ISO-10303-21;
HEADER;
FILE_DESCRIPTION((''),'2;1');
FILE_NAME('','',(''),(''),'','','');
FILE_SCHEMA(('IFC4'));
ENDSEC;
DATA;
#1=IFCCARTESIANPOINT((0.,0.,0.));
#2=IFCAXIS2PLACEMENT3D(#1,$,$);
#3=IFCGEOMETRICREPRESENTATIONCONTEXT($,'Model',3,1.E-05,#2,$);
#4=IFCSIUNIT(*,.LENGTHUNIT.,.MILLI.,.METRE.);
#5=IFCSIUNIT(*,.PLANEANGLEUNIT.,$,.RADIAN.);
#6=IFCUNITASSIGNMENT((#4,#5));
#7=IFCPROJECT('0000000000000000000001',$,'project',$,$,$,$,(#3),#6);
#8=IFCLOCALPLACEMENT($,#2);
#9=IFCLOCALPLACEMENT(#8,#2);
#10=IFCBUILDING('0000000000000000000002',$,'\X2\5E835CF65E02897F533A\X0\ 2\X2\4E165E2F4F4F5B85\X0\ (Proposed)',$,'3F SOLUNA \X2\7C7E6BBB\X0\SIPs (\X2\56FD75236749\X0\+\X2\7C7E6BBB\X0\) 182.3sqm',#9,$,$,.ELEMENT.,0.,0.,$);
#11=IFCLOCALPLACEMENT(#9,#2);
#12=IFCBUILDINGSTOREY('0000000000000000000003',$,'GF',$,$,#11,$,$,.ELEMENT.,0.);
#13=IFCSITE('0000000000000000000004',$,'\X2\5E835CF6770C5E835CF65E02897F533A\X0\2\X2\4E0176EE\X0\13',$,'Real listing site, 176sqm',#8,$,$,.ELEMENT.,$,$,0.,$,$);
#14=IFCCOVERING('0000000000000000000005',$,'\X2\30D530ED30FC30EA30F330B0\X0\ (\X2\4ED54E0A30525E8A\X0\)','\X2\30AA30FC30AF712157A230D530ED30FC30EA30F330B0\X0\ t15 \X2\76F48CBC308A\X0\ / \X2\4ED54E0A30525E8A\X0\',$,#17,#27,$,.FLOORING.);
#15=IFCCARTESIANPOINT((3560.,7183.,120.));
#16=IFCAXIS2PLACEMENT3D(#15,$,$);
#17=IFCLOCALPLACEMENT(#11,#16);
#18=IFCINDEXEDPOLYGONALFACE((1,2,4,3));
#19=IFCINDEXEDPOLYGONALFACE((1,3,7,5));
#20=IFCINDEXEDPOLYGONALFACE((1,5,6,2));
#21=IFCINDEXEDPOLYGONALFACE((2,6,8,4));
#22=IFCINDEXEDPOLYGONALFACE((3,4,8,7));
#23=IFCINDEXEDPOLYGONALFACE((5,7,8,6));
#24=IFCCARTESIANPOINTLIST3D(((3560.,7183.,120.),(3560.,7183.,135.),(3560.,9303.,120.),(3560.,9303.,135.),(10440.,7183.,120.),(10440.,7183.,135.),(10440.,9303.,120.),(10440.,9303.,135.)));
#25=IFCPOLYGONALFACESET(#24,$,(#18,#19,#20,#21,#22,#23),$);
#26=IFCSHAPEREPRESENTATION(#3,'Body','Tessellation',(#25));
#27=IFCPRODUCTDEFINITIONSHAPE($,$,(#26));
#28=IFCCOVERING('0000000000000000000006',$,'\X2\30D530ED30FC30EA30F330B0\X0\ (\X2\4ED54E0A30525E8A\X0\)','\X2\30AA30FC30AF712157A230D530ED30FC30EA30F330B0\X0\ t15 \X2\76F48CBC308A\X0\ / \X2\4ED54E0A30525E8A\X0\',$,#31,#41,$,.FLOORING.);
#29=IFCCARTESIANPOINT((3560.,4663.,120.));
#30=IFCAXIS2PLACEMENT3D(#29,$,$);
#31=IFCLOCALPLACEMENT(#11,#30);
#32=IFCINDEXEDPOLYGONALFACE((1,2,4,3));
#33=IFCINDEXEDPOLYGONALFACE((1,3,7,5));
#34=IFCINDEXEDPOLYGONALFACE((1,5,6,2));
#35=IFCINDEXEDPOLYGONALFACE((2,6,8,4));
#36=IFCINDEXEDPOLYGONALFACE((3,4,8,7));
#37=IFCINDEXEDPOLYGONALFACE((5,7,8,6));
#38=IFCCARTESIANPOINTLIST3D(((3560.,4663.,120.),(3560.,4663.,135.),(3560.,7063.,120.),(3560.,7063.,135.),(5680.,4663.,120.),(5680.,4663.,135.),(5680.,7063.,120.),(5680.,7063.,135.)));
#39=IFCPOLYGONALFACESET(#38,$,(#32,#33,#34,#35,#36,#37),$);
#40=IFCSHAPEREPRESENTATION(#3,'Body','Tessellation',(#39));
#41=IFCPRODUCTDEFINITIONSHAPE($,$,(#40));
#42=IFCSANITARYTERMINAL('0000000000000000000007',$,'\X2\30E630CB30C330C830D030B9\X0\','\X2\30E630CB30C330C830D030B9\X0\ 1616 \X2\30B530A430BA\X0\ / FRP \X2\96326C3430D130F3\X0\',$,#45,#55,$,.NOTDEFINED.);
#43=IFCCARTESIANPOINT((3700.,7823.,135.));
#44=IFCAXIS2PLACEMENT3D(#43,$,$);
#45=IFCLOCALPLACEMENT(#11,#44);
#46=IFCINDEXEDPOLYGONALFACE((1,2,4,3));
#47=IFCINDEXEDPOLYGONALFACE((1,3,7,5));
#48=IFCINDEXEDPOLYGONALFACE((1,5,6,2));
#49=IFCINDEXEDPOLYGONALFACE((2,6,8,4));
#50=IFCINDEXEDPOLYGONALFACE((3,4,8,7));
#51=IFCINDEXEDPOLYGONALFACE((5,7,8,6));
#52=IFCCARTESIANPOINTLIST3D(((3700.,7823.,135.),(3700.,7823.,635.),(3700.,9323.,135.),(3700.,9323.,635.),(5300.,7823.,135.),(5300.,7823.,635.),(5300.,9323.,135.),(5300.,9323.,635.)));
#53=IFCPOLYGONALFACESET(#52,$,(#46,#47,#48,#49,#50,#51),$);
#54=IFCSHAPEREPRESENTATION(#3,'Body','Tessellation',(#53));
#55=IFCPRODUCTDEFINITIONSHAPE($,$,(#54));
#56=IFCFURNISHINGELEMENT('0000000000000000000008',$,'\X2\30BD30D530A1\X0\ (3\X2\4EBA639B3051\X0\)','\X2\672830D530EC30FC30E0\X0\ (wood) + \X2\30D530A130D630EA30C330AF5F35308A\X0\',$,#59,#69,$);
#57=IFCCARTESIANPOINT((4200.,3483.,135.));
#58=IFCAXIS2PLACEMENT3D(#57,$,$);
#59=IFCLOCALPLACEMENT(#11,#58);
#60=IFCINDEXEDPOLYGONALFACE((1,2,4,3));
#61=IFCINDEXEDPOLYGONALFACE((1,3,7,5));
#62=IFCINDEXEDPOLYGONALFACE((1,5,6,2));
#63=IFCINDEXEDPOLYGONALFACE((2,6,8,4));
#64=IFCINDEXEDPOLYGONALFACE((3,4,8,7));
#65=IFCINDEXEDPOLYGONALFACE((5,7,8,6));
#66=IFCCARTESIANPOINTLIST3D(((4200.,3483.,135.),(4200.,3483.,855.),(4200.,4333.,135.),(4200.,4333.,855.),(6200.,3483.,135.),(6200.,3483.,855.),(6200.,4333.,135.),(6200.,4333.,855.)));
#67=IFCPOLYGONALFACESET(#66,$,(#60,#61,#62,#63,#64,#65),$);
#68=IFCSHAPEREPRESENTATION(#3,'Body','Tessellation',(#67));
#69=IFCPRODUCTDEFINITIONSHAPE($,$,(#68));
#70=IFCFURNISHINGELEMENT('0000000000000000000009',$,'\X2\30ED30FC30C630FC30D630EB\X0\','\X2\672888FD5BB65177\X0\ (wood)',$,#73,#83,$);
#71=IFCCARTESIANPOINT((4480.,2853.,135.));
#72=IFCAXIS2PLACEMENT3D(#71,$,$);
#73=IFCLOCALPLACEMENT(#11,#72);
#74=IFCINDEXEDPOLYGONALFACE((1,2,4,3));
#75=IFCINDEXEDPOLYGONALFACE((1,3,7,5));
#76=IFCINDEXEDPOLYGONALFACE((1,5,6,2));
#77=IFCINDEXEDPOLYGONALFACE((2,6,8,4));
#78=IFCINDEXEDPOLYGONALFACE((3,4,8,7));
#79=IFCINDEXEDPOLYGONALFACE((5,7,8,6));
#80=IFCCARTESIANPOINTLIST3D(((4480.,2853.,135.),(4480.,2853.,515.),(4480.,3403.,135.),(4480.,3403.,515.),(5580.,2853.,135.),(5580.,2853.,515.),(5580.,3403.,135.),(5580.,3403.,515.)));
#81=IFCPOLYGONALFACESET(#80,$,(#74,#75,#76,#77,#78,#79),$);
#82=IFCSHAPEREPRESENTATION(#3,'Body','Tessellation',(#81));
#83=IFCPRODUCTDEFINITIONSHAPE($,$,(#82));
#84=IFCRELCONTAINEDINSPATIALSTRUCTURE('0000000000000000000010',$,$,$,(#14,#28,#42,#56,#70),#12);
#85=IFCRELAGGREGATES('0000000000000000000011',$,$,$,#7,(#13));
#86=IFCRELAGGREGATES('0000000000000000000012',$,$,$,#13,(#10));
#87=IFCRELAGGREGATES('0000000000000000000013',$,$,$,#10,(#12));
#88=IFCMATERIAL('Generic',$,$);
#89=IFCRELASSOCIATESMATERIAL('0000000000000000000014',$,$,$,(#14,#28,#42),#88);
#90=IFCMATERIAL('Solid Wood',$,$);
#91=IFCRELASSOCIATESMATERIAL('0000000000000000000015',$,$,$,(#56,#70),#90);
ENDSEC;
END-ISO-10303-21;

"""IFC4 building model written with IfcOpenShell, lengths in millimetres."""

from ifc_helpers import new_model, si_unit, frame, frame_2d, origin, place, context, project, spatial, rectangle, extrude, material, element, save


model = new_model("IFC4")

# Units and contexts
model_context = context("Model", 3, precision=1e-05, world=origin())
ifc_project = project(units=[si_unit("LENGTHUNIT", "METRE", prefix="MILLI"), si_unit("PLANEANGLEUNIT", "RADIAN")], contexts=[model_context])

# Site, building, storey
site_placement = place(None, origin())
site = spatial("IfcSite", under=ifc_project, at=site_placement, Name="広島県広島市西区2丁目13", ObjectType="Real listing site, 176sqm", CompositionType="ELEMENT", RefElevation=0.0)
building_placement = place(site_placement, origin())
building = spatial("IfcBuilding", under=site, at=building_placement, Name="広島市西区 2世帯住宅 (Proposed)", ObjectType="3F SOLUNA 籾殻SIPs (国産杉+籾殻) 182.3sqm", CompositionType="ELEMENT", ElevationOfRefHeight=0.0, ElevationOfTerrain=0.0)
storey_placement = place(building_placement, origin())
storey = spatial("IfcBuildingStorey", under=building, at=storey_placement, Name="GF", CompositionType="ELEMENT", Elevation=0.0)

# Shared definitions
ifc_material_1 = material(Name="Solid Wood")

# Coverings
ifc_material_2 = material(Name="Generic")
covering_1_placement = place(storey_placement, frame((3560.0, 7183.0, 120.0)))
element("IfcCovering", 1, at=covering_1_placement, inside=storey, material=ifc_material_2, Name="フローリング (仕上げ床)", Description="オーク無垢フローリング t15 直貼り / 仕上げ床", PredefinedType="FLOORING", context=model_context, shape_type="SweptSolid", body=[
    extrude(rectangle(XDim=6880.0, YDim=2120.0, at=frame_2d((3440.0, 1060.0))), frame((3560.0, 7183.0, 120.0)), (0.0, 0.0, 1.0), 15.0),
])
covering_2_placement = place(storey_placement, frame((3560.0, 4663.0, 120.0)))
element("IfcCovering", 2, at=covering_2_placement, inside=storey, material=ifc_material_2, Name="フローリング (仕上げ床)", Description="オーク無垢フローリング t15 直貼り / 仕上げ床", PredefinedType="FLOORING", context=model_context, shape_type="SweptSolid", body=[
    extrude(rectangle(XDim=2120.0, YDim=2400.0, at=frame_2d((1060.0, 1200.0))), frame((3560.0, 4663.0, 120.0)), (0.0, 0.0, 1.0), 15.0),
])

# Sanitary terminal
sanitary_terminal_placement = place(storey_placement, frame((3700.0, 7823.0, 135.0)))
element("IfcSanitaryTerminal", 3, at=sanitary_terminal_placement, inside=storey, material=ifc_material_2, Name="ユニットバス", Description="ユニットバス 1616 サイズ / FRP 防水パン", PredefinedType="NOTDEFINED", context=model_context, shape_type="SweptSolid", body=[
    extrude(rectangle(XDim=1600.0, YDim=1500.0, at=frame_2d((800.0, 750.0))), frame((3700.0, 7823.0, 135.0)), (0.0, 0.0, 1.0), 500.0),
])

# Furnishing elements
furnishing_1_placement = place(storey_placement, frame((4200.0, 3483.0, 135.0)))
element("IfcFurnishingElement", 4, at=furnishing_1_placement, inside=storey, material=ifc_material_1, Name="ソファ (3人掛け)", Description="木フレーム (wood) + ファブリック張り", context=model_context, shape_type="SweptSolid", body=[
    extrude(rectangle(XDim=2000.0, YDim=850.0, at=frame_2d((1000.0, 425.0))), frame((4200.0, 3483.0, 135.0)), (0.0, 0.0, 1.0), 720.0),
])
furnishing_2_placement = place(storey_placement, frame((4480.0, 2853.0, 135.0)))
element("IfcFurnishingElement", 5, at=furnishing_2_placement, inside=storey, material=ifc_material_1, Name="ローテーブル", Description="木製家具 (wood)", context=model_context, shape_type="SweptSolid", body=[
    extrude(rectangle(XDim=1100.0, YDim=550.0, at=frame_2d((550.0, 275.0))), frame((4480.0, 2853.0, 135.0)), (0.0, 0.0, 1.0), 380.0),
])

save(model, "model.ifc")
